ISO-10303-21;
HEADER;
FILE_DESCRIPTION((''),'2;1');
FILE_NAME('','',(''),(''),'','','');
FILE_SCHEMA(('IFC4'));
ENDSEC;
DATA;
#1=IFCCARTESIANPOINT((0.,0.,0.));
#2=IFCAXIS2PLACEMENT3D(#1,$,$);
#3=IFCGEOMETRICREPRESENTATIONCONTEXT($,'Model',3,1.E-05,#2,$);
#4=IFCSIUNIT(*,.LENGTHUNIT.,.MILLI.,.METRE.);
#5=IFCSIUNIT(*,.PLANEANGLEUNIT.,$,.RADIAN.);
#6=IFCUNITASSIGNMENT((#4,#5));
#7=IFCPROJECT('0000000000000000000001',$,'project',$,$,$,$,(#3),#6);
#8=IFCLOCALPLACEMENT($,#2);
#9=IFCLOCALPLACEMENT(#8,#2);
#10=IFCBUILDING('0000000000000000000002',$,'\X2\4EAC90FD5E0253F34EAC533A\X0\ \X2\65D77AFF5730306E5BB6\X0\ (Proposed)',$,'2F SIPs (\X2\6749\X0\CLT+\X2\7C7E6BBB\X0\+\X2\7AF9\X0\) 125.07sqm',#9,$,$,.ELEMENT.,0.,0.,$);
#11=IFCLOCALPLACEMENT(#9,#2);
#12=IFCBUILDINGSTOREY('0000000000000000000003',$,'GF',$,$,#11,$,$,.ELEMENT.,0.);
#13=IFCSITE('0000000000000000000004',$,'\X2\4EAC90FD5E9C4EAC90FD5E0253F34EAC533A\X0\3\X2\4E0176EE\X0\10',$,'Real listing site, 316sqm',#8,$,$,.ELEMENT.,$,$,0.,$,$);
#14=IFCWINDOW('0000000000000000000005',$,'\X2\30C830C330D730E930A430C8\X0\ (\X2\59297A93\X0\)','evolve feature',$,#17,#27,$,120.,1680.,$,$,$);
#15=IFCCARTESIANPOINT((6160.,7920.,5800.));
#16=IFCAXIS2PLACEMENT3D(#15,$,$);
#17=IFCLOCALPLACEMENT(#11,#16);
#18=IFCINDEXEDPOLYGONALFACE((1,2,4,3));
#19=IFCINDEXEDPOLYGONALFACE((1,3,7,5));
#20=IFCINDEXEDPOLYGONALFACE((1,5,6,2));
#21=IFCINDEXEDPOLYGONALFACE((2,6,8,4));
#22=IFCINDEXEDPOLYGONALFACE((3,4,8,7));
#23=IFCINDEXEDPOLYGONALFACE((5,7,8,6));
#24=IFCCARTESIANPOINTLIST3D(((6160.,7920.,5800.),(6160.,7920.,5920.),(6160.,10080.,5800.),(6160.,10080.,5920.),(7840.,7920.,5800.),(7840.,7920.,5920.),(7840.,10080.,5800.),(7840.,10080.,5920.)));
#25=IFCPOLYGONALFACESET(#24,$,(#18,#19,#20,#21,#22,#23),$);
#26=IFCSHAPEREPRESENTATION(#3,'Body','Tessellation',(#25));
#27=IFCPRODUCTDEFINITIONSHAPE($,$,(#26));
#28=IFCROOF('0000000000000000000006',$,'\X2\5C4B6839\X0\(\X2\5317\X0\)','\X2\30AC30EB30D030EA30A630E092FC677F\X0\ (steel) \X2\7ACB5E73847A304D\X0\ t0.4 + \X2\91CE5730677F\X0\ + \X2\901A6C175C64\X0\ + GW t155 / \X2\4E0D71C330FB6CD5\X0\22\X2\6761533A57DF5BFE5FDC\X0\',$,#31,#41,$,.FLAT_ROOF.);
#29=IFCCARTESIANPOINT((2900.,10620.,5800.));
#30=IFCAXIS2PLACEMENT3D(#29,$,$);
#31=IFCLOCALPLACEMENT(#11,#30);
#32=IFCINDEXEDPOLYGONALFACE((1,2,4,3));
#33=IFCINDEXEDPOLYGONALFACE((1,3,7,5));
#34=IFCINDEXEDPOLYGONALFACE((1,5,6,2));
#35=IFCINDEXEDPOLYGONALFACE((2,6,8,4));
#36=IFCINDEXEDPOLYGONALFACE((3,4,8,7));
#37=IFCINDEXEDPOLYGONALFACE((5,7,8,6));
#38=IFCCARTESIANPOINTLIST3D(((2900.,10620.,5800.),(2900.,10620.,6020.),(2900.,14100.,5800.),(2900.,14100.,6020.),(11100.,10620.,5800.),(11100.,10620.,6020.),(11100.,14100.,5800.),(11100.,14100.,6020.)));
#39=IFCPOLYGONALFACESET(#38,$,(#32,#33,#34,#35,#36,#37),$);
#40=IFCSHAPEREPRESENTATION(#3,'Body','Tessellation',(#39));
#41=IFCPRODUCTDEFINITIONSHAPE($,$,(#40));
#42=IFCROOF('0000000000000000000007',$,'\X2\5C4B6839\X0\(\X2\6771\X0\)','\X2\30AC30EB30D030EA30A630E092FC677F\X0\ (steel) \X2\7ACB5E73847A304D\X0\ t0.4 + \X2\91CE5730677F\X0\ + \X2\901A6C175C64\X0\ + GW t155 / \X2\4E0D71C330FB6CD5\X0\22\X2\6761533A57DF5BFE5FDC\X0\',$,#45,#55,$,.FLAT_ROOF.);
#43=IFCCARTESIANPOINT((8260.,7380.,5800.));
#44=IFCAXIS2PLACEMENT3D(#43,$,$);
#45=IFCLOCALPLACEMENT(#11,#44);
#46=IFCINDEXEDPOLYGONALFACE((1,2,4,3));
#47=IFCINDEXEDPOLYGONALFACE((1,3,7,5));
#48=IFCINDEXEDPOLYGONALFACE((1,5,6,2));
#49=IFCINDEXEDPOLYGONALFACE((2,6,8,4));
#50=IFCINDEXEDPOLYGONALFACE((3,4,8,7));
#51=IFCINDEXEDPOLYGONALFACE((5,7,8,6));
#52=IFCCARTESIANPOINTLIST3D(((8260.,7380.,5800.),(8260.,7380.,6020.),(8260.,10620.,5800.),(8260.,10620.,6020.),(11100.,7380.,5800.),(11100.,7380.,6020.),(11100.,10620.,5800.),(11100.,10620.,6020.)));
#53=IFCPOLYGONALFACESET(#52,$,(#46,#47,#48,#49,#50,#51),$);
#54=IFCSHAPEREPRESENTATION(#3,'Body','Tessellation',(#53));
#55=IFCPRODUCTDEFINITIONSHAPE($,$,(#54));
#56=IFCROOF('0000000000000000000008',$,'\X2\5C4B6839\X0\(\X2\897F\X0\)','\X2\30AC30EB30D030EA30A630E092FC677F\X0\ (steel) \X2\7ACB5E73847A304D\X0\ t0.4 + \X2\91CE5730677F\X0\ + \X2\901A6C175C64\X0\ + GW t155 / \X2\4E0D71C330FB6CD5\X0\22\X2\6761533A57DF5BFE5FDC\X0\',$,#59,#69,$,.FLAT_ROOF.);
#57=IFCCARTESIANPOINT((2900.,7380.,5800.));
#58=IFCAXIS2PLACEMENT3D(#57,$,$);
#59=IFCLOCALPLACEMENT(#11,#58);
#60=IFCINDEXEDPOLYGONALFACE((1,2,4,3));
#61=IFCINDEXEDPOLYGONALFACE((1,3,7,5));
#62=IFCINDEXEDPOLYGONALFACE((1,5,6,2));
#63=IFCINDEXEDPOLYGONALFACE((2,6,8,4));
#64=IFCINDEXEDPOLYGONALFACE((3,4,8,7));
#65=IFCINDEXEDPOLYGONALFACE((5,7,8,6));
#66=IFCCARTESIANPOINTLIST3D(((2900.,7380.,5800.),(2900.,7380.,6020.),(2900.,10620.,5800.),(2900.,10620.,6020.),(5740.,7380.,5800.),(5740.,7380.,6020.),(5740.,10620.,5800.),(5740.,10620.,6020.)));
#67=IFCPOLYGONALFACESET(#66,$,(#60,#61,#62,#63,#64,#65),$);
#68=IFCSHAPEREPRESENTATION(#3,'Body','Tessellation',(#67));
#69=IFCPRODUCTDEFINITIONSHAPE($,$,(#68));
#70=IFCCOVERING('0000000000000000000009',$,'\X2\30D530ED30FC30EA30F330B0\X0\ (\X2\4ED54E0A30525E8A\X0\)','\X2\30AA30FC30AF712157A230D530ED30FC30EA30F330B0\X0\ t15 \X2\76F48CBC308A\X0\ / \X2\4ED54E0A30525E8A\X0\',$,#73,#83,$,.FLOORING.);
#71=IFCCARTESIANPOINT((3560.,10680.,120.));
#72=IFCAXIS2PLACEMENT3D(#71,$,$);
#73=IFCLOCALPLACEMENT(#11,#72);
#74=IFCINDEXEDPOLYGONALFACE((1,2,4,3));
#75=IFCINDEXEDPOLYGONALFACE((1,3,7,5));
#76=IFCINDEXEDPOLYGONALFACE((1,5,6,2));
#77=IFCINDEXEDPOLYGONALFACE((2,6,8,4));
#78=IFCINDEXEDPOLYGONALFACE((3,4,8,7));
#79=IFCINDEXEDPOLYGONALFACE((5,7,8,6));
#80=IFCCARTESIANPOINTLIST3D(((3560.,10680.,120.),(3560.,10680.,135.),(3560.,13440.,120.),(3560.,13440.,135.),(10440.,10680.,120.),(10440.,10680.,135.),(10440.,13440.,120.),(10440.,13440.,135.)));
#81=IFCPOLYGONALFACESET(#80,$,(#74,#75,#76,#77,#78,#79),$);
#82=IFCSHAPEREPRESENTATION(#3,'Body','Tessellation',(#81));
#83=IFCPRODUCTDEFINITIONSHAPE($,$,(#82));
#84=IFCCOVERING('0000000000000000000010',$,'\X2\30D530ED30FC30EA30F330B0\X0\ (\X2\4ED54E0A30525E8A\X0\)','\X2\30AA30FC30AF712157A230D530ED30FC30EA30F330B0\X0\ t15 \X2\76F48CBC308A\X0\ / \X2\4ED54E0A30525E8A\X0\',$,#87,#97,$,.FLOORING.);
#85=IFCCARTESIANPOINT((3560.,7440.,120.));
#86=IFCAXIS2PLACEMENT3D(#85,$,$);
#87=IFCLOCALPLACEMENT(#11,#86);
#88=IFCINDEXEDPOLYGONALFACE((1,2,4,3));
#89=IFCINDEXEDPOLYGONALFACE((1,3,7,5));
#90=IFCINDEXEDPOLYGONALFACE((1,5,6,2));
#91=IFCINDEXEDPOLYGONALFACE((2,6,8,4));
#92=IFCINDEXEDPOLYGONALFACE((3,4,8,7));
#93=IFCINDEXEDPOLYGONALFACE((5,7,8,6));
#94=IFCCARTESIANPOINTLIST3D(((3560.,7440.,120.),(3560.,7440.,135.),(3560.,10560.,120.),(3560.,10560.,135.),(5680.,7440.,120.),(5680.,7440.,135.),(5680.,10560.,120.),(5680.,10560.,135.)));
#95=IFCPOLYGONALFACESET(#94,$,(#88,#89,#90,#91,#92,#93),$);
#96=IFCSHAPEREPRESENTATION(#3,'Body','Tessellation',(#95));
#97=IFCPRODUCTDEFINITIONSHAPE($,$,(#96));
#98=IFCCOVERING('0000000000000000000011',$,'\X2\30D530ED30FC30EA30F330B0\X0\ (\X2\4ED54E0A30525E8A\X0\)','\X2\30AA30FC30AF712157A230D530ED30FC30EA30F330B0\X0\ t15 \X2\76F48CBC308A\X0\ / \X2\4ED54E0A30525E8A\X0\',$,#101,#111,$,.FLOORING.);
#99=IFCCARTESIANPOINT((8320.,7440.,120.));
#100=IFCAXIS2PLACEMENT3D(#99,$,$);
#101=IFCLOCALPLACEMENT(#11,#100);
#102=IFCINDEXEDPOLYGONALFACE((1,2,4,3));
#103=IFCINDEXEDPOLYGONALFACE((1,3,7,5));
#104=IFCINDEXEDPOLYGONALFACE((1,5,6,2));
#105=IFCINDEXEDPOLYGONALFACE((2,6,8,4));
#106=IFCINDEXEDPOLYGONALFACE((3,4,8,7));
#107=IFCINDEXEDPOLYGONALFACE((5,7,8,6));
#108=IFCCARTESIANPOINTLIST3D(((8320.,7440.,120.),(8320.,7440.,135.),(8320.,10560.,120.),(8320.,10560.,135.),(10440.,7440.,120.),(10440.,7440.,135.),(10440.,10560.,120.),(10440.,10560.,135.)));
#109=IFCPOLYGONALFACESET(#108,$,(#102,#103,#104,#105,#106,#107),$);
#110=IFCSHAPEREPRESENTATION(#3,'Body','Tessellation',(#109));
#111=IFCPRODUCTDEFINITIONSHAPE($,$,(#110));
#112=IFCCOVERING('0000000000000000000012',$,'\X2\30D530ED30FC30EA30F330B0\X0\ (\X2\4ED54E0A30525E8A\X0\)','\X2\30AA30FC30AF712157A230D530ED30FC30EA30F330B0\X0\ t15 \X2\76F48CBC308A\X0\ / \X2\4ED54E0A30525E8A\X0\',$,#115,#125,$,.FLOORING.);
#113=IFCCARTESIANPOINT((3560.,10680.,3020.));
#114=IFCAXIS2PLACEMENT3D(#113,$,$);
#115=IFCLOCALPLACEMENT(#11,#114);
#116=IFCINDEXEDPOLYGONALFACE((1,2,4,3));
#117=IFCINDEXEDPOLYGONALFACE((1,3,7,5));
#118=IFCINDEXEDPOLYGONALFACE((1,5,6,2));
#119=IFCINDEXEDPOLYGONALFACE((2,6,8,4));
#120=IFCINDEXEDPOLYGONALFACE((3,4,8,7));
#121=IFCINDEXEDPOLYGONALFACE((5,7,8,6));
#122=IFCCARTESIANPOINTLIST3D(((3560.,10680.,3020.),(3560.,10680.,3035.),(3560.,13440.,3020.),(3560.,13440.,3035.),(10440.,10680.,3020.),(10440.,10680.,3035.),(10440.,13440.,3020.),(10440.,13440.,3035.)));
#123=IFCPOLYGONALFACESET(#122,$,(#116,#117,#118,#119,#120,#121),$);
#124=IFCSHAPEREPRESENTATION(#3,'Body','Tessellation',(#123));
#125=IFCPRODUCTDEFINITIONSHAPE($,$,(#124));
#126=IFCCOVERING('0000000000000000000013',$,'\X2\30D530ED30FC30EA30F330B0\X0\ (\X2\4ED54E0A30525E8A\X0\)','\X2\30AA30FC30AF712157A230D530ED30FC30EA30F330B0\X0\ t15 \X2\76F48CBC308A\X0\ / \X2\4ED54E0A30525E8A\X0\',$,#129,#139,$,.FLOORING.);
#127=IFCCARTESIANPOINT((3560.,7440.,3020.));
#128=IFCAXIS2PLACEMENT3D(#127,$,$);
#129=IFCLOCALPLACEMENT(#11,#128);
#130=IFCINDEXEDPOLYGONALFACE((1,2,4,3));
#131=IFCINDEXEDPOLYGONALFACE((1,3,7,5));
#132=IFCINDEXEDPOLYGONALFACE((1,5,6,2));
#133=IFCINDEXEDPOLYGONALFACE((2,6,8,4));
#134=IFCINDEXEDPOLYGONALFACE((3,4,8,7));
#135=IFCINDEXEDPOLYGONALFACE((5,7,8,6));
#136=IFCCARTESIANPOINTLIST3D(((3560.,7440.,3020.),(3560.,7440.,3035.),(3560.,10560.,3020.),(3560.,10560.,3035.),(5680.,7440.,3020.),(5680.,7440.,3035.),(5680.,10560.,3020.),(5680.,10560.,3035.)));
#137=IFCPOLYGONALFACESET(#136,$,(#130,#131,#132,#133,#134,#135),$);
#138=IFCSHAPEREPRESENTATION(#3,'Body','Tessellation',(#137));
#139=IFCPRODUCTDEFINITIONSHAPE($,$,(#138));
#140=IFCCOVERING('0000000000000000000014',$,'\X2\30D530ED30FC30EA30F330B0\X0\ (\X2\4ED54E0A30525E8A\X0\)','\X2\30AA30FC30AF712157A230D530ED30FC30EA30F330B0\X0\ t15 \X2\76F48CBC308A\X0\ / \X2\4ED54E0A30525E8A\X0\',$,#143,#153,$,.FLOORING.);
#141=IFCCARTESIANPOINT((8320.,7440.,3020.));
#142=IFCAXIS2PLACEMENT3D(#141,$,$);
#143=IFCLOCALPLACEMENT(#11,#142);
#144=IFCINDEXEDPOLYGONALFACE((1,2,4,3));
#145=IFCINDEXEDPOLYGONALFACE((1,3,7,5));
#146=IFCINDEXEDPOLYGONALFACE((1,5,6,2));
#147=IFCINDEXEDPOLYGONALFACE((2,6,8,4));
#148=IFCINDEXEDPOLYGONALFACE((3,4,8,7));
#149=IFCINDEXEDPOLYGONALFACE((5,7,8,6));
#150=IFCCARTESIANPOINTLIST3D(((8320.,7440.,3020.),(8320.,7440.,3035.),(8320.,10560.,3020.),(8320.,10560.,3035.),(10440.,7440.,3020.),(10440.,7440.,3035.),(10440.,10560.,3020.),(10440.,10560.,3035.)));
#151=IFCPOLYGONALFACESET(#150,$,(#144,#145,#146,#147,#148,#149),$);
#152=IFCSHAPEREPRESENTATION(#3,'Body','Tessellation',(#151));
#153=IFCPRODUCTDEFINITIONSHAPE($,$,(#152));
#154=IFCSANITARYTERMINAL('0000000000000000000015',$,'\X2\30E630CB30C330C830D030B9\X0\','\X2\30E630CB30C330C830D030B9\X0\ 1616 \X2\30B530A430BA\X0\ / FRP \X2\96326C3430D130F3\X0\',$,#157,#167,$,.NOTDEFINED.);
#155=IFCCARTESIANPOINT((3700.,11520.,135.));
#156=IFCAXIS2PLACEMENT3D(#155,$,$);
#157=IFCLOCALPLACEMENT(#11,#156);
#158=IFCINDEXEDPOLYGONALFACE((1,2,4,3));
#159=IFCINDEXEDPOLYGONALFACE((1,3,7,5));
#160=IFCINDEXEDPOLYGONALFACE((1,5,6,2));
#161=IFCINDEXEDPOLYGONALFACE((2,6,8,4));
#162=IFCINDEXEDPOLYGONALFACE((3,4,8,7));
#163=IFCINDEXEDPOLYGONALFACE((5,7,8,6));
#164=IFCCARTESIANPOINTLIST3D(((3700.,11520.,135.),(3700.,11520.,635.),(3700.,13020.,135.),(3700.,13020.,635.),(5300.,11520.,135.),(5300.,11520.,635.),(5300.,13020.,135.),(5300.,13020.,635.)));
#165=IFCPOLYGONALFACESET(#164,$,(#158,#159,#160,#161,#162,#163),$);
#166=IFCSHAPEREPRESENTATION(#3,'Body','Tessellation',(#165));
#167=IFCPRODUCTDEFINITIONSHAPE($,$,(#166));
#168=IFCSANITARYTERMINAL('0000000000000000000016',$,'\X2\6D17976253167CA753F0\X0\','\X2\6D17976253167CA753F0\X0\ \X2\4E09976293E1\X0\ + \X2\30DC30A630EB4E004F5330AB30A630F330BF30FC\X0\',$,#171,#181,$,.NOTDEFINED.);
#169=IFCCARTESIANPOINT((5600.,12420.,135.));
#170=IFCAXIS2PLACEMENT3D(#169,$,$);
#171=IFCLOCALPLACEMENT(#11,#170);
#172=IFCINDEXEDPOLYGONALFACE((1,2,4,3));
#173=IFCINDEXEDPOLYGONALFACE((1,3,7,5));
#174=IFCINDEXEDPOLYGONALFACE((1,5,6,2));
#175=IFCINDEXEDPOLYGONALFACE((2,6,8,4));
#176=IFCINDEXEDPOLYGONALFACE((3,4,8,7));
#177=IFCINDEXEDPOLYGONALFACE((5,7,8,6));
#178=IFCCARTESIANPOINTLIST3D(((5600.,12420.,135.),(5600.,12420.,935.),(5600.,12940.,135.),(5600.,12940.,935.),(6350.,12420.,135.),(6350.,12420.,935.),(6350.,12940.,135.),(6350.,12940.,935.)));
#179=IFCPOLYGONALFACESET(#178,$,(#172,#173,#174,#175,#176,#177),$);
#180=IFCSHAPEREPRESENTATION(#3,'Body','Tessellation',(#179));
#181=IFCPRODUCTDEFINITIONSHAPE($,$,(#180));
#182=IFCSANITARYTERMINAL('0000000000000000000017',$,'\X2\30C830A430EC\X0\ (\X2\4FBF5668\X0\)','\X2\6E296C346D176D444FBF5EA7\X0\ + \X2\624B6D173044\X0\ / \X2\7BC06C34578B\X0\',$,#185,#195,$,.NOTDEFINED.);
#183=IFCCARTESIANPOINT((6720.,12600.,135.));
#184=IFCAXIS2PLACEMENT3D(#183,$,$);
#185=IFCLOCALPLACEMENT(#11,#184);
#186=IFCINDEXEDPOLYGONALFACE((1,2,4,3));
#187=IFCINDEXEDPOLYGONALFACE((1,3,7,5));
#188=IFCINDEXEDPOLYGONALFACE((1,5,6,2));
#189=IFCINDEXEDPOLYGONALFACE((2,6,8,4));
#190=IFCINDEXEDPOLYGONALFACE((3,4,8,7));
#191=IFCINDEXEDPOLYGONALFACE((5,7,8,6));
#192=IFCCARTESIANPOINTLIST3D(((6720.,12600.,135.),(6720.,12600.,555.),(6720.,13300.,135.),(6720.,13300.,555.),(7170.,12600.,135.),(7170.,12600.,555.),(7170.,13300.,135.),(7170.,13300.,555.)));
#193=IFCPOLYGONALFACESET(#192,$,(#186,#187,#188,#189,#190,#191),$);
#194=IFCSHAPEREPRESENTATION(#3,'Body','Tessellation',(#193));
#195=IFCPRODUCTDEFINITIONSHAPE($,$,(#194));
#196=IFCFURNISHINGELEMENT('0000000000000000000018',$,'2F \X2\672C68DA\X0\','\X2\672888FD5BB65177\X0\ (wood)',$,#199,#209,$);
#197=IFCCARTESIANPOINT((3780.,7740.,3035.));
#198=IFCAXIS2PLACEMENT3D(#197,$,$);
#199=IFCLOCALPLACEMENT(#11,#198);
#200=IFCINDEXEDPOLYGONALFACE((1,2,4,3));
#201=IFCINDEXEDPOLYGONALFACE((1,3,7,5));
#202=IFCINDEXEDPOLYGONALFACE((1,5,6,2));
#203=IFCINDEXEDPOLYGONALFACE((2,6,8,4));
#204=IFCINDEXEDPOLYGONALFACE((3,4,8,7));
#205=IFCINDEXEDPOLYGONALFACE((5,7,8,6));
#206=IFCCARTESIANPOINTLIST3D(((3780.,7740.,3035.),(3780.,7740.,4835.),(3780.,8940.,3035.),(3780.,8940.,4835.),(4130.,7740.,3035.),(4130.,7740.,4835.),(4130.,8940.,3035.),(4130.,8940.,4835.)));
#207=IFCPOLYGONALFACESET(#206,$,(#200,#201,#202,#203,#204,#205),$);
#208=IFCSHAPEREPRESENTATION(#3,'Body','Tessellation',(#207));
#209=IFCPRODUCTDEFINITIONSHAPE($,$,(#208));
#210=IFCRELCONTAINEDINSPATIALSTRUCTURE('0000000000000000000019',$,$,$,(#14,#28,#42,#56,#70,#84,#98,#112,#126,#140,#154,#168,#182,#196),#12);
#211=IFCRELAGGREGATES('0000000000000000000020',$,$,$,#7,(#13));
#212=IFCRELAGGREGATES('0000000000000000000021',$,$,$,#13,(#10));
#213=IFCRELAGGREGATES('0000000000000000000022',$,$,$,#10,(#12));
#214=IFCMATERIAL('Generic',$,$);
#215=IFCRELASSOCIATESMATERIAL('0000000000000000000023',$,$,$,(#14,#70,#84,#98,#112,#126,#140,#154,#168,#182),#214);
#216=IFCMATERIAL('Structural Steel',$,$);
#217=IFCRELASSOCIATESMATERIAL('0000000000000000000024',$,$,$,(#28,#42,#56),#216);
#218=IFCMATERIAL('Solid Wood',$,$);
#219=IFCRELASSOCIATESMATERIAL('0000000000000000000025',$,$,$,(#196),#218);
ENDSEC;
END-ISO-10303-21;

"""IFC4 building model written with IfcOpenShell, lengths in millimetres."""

from ifc_helpers import new_model, si_unit, frame, frame_2d, origin, place, context, project, spatial, rectangle, extrude, material, element, save


model = new_model("IFC4")

# Units and contexts
model_context = context("Model", 3, precision=1e-05, world=origin())
ifc_project = project(units=[si_unit("LENGTHUNIT", "METRE", prefix="MILLI"), si_unit("PLANEANGLEUNIT", "RADIAN")], contexts=[model_context])

# Site, building, storey
site_placement = place(None, origin())
site = spatial("IfcSite", under=ifc_project, at=site_placement, Name="京都府京都市右京区3丁目10", ObjectType="Real listing site, 316sqm", CompositionType="ELEMENT", RefElevation=0.0)
building_placement = place(site_placement, origin())
building = spatial("IfcBuilding", under=site, at=building_placement, Name="京都市右京区 旗竿地の家 (Proposed)", ObjectType="2F SIPs (杉CLT+籾殻+竹) 125.07sqm", CompositionType="ELEMENT", ElevationOfRefHeight=0.0, ElevationOfTerrain=0.0)
storey_placement = place(building_placement, origin())
storey = spatial("IfcBuildingStorey", under=building, at=storey_placement, Name="GF", CompositionType="ELEMENT", Elevation=0.0)

# Shared definitions
ifc_material_1 = material(Name="Solid Wood")

# Window
ifc_material_2 = material(Name="Generic")
window_1_placement = place(storey_placement, frame((6160.0, 7920.0, 5800.0)))
element("IfcWindow", 1, at=window_1_placement, inside=storey, material=ifc_material_2, Name="トップライト (天窓)", Description="evolve feature", OverallHeight=120.0, OverallWidth=1680.0, context=model_context, shape_type="SweptSolid", body=[
    extrude(rectangle(XDim=1680.0, YDim=2160.0, at=frame_2d((840.0, 1080.0))), frame((6160.0, 7920.0, 5800.0)), (0.0, 0.0, 1.0), 120.0),
])

# Roofs
ifc_material_3 = material(Name="Structural Steel")
roof_1_placement = place(storey_placement, frame((2900.0, 10620.0, 5800.0)))
element("IfcRoof", 2, at=roof_1_placement, inside=storey, material=ifc_material_3, Name="屋根(北)", Description="ガルバリウム鋼板 (steel) 立平葺き t0.4 + 野地板 + 通気層 + GW t155 / 不燃・法22条区域対応", PredefinedType="FLAT_ROOF", context=model_context, shape_type="SweptSolid", body=[
    extrude(rectangle(XDim=8200.0, YDim=3480.0, at=frame_2d((4100.0, 1740.0))), frame((2900.0, 10620.0, 5800.0)), (0.0, 0.0, 1.0), 220.0),
])
roof_2_placement = place(storey_placement, frame((8260.0, 7380.0, 5800.0)))
element("IfcRoof", 3, at=roof_2_placement, inside=storey, material=ifc_material_3, Name="屋根(東)", Description="ガルバリウム鋼板 (steel) 立平葺き t0.4 + 野地板 + 通気層 + GW t155 / 不燃・法22条区域対応", PredefinedType="FLAT_ROOF", context=model_context, shape_type="SweptSolid", body=[
    extrude(rectangle(XDim=2840.0, YDim=3240.0, at=frame_2d((1420.0, 1620.0))), frame((8260.0, 7380.0, 5800.0)), (0.0, 0.0, 1.0), 220.0),
])
roof_3_placement = place(storey_placement, frame((2900.0, 7380.0, 5800.0)))
element("IfcRoof", 4, at=roof_3_placement, inside=storey, material=ifc_material_3, Name="屋根(西)", Description="ガルバリウム鋼板 (steel) 立平葺き t0.4 + 野地板 + 通気層 + GW t155 / 不燃・法22条区域対応", PredefinedType="FLAT_ROOF", context=model_context, shape_type="SweptSolid", body=[
    extrude(rectangle(XDim=2840.0, YDim=3240.0, at=frame_2d((1420.0, 1620.0))), frame((2900.0, 7380.0, 5800.0)), (0.0, 0.0, 1.0), 220.0),
])

# Coverings
covering_1_placement = place(storey_placement, frame((3560.0, 10680.0, 120.0)))
element("IfcCovering", 5, at=covering_1_placement, inside=storey, material=ifc_material_2, Name="フローリング (仕上げ床)", Description="オーク無垢フローリング t15 直貼り / 仕上げ床", PredefinedType="FLOORING", context=model_context, shape_type="SweptSolid", body=[
    extrude(rectangle(XDim=6880.0, YDim=2760.0, at=frame_2d((3440.0, 1380.0))), frame((3560.0, 10680.0, 120.0)), (0.0, 0.0, 1.0), 15.0),
])
covering_2_placement = place(storey_placement, frame((3560.0, 7440.0, 120.0)))
element("IfcCovering", 6, at=covering_2_placement, inside=storey, material=ifc_material_2, Name="フローリング (仕上げ床)", Description="オーク無垢フローリング t15 直貼り / 仕上げ床", PredefinedType="FLOORING", context=model_context, shape_type="SweptSolid", body=[
    extrude(rectangle(XDim=2120.0, YDim=3120.0, at=frame_2d((1060.0, 1560.0))), frame((3560.0, 7440.0, 120.0)), (0.0, 0.0, 1.0), 15.0),
])
covering_3_placement = place(storey_placement, frame((8320.0, 7440.0, 120.0)))
element("IfcCovering", 7, at=covering_3_placement, inside=storey, material=ifc_material_2, Name="フローリング (仕上げ床)", Description="オーク無垢フローリング t15 直貼り / 仕上げ床", PredefinedType="FLOORING", context=model_context, shape_type="SweptSolid", body=[
    extrude(rectangle(XDim=2120.0, YDim=3120.0, at=frame_2d((1060.0, 1560.0))), frame((8320.0, 7440.0, 120.0)), (0.0, 0.0, 1.0), 15.0),
])
covering_4_placement = place(storey_placement, frame((3560.0, 10680.0, 3020.0)))
element("IfcCovering", 8, at=covering_4_placement, inside=storey, material=ifc_material_2, Name="フローリング (仕上げ床)", Description="オーク無垢フローリング t15 直貼り / 仕上げ床", PredefinedType="FLOORING", context=model_context, shape_type="SweptSolid", body=[
    extrude(rectangle(XDim=6880.0, YDim=2760.0, at=frame_2d((3440.0, 1380.0))), frame((3560.0, 10680.0, 3020.0)), (0.0, 0.0, 1.0), 15.0),
])
covering_5_placement = place(storey_placement, frame((3560.0, 7440.0, 3020.0)))
element("IfcCovering", 9, at=covering_5_placement, inside=storey, material=ifc_material_2, Name="フローリング (仕上げ床)", Description="オーク無垢フローリング t15 直貼り / 仕上げ床", PredefinedType="FLOORING", context=model_context, shape_type="SweptSolid", body=[
    extrude(rectangle(XDim=2120.0, YDim=3120.0, at=frame_2d((1060.0, 1560.0))), frame((3560.0, 7440.0, 3020.0)), (0.0, 0.0, 1.0), 15.0),
])
covering_6_placement = place(storey_placement, frame((8320.0, 7440.0, 3020.0)))
element("IfcCovering", 10, at=covering_6_placement, inside=storey, material=ifc_material_2, Name="フローリング (仕上げ床)", Description="オーク無垢フローリング t15 直貼り / 仕上げ床", PredefinedType="FLOORING", context=model_context, shape_type="SweptSolid", body=[
    extrude(rectangle(XDim=2120.0, YDim=3120.0, at=frame_2d((1060.0, 1560.0))), frame((8320.0, 7440.0, 3020.0)), (0.0, 0.0, 1.0), 15.0),
])

# Sanitary terminals
sanitary_terminal_1_placement = place(storey_placement, frame((3700.0, 11520.0, 135.0)))
element("IfcSanitaryTerminal", 11, at=sanitary_terminal_1_placement, inside=storey, material=ifc_material_2, Name="ユニットバス", Description="ユニットバス 1616 サイズ / FRP 防水パン", PredefinedType="NOTDEFINED", context=model_context, shape_type="SweptSolid", body=[
    extrude(rectangle(XDim=1600.0, YDim=1500.0, at=frame_2d((800.0, 750.0))), frame((3700.0, 11520.0, 135.0)), (0.0, 0.0, 1.0), 500.0),
])
sanitary_terminal_2_placement = place(storey_placement, frame((5600.0, 12420.0, 135.0)))
element("IfcSanitaryTerminal", 12, at=sanitary_terminal_2_placement, inside=storey, material=ifc_material_2, Name="洗面化粧台", Description="洗面化粧台 三面鏡 + ボウル一体カウンター", PredefinedType="NOTDEFINED", context=model_context, shape_type="SweptSolid", body=[
    extrude(rectangle(XDim=750.0, YDim=520.0, at=frame_2d((375.0, 260.0))), frame((5600.0, 12420.0, 135.0)), (0.0, 0.0, 1.0), 800.0),
])
sanitary_terminal_3_placement = place(storey_placement, frame((6720.0, 12600.0, 135.0)))
element("IfcSanitaryTerminal", 13, at=sanitary_terminal_3_placement, inside=storey, material=ifc_material_2, Name="トイレ (便器)", Description="温水洗浄便座 + 手洗い / 節水型", PredefinedType="NOTDEFINED", context=model_context, shape_type="SweptSolid", body=[
    extrude(rectangle(XDim=450.0, YDim=700.0, at=frame_2d((225.0, 350.0))), frame((6720.0, 12600.0, 135.0)), (0.0, 0.0, 1.0), 420.0),
])

# Furnishing element
furnishing_placement = place(storey_placement, frame((3780.0, 7740.0, 3035.0)))
element("IfcFurnishingElement", 14, at=furnishing_placement, inside=storey, material=ifc_material_1, Name="2F 本棚", Description="木製家具 (wood)", context=model_context, shape_type="SweptSolid", body=[
    extrude(rectangle(XDim=350.0, YDim=1200.0, at=frame_2d((175.0, 600.0))), frame((3780.0, 7740.0, 3035.0)), (0.0, 0.0, 1.0), 1800.0),
])

save(model, "model.ifc")
